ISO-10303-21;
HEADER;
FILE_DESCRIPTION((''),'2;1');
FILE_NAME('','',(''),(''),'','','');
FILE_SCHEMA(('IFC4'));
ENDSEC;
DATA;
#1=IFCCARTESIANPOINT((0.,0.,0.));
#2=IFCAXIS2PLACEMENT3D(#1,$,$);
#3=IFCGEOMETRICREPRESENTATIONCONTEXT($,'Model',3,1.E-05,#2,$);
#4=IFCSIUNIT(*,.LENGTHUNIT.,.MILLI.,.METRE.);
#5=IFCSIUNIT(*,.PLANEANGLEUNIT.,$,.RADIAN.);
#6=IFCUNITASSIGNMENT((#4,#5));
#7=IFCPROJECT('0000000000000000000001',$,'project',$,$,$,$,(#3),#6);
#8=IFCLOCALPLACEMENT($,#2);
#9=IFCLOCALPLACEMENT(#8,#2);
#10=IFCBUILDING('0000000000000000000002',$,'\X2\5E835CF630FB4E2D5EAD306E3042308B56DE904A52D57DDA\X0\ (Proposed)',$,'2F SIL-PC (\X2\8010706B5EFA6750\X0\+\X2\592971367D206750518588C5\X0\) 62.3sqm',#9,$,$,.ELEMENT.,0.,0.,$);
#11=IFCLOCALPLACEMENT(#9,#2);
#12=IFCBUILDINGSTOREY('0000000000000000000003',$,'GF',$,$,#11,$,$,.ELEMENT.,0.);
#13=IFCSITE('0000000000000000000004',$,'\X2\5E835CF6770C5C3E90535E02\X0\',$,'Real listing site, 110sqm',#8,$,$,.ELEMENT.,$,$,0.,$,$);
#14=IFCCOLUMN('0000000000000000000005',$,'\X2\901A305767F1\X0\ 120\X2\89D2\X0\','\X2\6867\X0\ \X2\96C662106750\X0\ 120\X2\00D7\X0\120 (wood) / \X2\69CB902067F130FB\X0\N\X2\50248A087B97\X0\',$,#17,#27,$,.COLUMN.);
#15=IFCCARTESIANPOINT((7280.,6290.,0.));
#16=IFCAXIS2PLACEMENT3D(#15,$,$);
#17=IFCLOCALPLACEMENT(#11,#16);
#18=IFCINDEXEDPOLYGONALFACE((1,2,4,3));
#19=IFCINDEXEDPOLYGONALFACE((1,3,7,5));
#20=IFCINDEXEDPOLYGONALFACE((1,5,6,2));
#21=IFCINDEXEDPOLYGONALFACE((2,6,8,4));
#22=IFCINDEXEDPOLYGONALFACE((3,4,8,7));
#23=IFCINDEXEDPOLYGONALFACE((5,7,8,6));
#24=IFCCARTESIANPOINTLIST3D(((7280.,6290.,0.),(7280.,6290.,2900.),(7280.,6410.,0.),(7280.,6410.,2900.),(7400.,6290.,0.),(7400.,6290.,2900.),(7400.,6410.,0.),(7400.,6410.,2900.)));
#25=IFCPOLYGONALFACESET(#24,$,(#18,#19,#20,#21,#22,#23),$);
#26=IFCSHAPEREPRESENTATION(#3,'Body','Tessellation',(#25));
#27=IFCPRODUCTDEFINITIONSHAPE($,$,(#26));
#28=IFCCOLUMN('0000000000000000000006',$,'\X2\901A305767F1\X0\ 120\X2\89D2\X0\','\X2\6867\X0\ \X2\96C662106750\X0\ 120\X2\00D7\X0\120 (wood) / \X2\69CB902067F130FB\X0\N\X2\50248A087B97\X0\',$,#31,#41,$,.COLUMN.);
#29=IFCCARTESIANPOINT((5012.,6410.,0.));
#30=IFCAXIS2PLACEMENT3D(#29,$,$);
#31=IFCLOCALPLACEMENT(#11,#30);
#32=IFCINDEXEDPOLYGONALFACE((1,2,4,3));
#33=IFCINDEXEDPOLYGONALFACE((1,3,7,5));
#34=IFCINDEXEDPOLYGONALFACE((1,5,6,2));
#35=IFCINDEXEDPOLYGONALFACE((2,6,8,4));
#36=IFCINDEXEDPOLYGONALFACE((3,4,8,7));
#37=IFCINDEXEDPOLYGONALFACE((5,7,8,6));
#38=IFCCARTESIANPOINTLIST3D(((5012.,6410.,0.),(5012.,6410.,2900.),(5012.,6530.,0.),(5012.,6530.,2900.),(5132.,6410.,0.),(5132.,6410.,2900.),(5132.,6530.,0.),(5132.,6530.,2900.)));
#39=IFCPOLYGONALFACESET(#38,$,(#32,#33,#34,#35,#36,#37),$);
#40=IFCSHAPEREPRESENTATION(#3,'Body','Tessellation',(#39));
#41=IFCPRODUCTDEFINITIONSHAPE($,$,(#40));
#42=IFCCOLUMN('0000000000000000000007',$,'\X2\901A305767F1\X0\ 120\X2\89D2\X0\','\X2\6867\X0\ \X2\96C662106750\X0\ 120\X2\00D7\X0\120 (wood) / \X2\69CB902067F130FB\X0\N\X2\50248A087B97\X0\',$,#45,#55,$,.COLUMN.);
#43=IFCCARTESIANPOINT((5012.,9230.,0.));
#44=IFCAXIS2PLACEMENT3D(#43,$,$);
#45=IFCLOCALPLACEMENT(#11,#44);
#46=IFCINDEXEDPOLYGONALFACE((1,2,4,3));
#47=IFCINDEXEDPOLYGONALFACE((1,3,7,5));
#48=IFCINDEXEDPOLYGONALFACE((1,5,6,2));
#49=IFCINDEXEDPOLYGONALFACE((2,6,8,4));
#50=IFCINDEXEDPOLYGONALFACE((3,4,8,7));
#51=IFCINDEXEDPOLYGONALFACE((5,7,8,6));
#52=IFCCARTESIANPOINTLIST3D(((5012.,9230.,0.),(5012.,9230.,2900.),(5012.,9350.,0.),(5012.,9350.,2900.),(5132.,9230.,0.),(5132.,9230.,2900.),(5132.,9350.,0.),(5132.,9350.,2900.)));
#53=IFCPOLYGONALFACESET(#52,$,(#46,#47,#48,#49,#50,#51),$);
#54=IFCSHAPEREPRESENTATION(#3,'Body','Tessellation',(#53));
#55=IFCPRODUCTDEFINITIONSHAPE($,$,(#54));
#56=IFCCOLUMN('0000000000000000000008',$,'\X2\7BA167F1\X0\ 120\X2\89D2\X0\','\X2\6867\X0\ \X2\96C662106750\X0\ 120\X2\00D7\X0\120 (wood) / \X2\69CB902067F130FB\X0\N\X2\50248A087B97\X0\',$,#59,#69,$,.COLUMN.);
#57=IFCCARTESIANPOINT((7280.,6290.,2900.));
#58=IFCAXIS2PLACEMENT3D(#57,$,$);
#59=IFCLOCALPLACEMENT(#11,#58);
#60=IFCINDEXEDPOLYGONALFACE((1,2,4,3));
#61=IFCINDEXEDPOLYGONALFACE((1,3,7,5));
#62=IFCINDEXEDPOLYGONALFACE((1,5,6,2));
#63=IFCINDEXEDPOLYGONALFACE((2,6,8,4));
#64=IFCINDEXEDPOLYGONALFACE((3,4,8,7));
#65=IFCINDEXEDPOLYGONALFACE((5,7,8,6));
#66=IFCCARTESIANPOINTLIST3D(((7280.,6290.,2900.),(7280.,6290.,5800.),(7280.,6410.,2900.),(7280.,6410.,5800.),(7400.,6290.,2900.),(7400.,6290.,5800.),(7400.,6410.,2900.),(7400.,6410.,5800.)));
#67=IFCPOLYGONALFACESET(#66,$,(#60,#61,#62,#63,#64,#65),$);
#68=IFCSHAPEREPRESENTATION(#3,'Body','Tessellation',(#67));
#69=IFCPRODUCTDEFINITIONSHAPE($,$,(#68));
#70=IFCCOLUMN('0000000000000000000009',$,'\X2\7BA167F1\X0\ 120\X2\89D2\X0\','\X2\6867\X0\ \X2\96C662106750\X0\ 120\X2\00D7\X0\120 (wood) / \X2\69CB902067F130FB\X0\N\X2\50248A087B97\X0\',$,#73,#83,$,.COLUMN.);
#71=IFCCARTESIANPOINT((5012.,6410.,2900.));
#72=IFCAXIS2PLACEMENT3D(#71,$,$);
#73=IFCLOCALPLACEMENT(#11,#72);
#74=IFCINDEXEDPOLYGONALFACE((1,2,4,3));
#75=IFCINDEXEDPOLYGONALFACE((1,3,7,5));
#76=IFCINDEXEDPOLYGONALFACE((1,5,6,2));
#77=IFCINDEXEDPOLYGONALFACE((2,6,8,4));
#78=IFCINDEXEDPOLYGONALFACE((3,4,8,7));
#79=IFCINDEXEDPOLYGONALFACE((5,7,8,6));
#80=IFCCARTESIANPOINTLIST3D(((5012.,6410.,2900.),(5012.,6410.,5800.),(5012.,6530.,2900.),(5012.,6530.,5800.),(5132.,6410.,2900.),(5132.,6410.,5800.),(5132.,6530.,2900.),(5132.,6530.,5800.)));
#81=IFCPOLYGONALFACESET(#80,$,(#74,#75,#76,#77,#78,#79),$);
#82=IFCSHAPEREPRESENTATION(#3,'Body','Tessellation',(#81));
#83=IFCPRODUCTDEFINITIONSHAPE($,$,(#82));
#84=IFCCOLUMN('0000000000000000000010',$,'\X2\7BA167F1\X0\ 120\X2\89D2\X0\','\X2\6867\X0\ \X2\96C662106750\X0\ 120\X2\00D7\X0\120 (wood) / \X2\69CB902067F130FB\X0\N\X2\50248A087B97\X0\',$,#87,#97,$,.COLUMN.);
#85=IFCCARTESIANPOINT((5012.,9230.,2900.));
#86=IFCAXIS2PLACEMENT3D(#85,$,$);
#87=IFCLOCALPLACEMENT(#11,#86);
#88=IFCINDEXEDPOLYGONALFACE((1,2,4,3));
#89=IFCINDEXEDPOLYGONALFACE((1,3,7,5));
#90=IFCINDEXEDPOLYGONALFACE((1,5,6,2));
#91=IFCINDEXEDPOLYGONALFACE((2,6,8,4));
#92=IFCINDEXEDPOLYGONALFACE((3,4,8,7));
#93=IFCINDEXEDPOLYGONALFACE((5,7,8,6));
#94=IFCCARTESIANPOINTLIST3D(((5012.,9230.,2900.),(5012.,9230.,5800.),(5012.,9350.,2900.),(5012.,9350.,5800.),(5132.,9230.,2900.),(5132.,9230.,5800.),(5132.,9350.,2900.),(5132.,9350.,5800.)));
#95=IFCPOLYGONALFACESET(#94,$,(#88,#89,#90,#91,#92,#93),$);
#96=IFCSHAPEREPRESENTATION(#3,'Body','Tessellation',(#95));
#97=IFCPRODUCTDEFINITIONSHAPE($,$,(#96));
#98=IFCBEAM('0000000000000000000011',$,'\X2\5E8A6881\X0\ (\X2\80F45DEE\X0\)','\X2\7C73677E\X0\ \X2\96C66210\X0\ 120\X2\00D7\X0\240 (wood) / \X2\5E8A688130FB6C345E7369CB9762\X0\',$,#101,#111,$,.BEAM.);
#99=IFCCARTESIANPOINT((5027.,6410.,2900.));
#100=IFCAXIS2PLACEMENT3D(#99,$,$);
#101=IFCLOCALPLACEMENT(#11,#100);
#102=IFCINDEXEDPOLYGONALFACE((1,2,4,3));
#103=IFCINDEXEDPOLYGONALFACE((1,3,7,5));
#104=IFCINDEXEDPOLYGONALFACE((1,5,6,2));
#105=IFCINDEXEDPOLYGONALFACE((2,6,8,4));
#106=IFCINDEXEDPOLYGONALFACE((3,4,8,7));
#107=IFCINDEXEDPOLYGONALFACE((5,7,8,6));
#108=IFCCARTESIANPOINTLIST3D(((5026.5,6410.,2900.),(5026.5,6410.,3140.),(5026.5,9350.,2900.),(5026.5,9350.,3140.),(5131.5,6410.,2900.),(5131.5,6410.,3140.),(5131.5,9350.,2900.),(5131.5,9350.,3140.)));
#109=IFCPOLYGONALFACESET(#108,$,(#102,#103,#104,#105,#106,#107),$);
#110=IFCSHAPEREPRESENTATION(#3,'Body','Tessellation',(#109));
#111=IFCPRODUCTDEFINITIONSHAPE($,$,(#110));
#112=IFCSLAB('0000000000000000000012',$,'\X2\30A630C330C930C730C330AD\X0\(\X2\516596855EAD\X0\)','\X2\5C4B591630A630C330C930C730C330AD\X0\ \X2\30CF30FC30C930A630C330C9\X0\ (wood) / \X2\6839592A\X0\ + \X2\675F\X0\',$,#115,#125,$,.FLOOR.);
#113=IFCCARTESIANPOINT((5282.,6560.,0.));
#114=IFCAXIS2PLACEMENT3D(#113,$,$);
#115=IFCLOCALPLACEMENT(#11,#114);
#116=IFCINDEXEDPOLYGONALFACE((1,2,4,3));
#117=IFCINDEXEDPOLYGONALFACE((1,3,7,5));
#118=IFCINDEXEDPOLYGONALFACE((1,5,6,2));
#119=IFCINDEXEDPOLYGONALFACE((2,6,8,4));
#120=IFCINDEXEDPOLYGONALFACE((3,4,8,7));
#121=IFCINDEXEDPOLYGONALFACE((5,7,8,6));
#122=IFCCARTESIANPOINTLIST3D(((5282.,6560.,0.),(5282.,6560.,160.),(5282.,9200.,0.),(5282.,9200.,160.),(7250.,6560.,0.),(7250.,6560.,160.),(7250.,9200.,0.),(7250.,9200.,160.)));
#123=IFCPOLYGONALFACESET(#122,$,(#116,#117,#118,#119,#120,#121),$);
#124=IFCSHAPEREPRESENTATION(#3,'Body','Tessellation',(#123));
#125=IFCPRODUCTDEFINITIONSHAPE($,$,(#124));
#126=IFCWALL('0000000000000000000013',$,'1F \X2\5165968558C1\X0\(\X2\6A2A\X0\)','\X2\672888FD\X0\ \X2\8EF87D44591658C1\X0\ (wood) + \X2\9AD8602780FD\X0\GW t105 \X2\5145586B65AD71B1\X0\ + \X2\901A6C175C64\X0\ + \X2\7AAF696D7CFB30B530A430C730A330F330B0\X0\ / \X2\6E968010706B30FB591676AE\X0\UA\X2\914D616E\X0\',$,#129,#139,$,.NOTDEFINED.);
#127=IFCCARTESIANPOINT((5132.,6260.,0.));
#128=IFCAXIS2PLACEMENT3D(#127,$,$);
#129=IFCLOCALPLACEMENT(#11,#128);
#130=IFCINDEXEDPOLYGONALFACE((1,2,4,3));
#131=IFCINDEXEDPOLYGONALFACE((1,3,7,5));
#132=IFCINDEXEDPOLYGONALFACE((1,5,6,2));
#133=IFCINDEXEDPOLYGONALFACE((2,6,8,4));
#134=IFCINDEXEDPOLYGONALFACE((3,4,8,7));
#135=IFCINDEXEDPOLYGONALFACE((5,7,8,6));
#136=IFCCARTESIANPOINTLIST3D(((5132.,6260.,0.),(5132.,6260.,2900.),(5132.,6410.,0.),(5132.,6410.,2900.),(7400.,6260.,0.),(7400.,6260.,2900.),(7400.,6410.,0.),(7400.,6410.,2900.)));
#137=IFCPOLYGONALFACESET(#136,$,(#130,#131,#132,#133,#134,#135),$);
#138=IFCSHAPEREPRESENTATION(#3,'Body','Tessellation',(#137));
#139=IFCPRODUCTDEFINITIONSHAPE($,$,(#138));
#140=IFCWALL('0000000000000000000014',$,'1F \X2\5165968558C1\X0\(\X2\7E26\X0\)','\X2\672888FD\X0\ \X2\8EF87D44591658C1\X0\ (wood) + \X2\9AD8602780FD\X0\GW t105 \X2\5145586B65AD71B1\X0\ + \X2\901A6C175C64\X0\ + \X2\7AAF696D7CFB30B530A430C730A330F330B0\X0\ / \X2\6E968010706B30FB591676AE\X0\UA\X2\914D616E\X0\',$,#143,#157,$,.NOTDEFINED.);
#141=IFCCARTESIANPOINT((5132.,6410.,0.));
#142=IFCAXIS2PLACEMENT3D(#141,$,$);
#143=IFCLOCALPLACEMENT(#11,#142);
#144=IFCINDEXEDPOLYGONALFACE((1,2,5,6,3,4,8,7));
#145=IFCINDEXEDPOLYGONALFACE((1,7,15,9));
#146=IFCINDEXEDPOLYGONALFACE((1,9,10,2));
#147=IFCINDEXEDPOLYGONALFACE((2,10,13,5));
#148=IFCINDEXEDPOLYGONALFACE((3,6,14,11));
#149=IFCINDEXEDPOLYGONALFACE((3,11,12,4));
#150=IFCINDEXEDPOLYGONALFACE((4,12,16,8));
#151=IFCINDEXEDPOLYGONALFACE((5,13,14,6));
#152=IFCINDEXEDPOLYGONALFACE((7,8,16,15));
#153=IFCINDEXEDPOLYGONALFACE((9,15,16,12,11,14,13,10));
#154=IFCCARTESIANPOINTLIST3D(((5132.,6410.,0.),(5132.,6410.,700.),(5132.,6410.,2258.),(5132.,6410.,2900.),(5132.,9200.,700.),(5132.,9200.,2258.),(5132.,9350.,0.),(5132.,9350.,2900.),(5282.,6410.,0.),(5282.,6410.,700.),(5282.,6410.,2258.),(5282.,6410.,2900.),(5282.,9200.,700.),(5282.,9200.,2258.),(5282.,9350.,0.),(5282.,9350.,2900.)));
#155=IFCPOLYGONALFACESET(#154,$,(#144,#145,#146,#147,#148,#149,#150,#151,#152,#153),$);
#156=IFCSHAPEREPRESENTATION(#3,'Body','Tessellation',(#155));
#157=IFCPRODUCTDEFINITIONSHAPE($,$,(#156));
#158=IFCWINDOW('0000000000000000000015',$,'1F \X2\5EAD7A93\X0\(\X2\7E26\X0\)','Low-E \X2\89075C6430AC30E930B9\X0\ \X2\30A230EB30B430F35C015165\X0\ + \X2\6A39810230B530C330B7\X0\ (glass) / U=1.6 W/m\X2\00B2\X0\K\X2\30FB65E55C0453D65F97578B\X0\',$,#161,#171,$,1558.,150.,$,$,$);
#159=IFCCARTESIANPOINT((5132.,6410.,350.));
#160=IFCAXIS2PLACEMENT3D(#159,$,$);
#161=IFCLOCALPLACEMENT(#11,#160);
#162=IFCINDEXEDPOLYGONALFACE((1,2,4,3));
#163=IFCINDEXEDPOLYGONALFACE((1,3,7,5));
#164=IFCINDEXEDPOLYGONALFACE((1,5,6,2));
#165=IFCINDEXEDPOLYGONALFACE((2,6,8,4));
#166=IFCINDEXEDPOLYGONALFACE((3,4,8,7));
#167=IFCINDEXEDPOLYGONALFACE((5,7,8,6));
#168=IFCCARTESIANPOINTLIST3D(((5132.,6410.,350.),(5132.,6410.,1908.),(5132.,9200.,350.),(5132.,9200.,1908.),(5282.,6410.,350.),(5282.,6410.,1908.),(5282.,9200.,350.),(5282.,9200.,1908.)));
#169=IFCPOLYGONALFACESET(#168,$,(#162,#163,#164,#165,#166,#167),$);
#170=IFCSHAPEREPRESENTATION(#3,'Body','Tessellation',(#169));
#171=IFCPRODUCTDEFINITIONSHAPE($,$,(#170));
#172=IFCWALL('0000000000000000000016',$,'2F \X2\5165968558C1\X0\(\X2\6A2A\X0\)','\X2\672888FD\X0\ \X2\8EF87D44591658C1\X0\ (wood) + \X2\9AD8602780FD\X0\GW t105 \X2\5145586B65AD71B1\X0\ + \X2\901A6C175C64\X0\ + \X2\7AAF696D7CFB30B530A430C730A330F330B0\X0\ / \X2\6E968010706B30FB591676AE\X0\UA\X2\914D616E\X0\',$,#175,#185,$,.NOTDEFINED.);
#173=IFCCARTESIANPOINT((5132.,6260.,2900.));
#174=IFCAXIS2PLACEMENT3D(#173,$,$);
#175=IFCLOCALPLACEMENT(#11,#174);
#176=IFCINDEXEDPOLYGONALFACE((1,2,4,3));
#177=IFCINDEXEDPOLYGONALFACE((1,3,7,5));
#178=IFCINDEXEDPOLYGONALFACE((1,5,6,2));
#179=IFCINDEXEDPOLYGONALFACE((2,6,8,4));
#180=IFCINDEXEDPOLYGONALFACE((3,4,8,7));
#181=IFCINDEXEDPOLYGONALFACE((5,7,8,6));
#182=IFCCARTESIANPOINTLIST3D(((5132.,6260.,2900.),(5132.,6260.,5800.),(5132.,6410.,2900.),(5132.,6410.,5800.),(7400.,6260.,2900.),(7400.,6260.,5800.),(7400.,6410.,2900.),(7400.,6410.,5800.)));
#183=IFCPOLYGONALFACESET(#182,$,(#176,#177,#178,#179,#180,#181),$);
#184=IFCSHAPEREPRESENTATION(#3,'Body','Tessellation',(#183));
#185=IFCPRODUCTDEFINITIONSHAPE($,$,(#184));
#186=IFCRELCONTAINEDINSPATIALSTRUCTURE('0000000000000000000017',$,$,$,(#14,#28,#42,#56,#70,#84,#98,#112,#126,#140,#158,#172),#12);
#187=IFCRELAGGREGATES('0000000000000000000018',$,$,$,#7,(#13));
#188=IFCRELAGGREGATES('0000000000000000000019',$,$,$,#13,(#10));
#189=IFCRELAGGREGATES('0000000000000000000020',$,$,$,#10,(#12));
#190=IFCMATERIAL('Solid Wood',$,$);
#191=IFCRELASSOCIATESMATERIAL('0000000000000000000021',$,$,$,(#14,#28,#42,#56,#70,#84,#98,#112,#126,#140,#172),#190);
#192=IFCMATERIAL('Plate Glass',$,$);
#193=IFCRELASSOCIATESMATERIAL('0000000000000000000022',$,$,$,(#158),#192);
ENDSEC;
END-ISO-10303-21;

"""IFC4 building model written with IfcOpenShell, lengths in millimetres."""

from ifc_helpers import new_model, si_unit, frame, frame_2d, origin, place, context, project, spatial, rectangle, extrude, material, element, fill, save


model = new_model("IFC4")

# Units and contexts
model_context = context("Model", 3, precision=1e-05, world=origin())
ifc_project = project(units=[si_unit("LENGTHUNIT", "METRE", prefix="MILLI"), si_unit("PLANEANGLEUNIT", "RADIAN")], contexts=[model_context])

# Site, building, storey
site_placement = place(None, origin())
site = spatial("IfcSite", under=ifc_project, at=site_placement, Name="広島県尾道市", ObjectType="Real listing site, 110sqm", CompositionType="ELEMENT", RefElevation=0.0)
building_placement = place(site_placement, origin())
building = spatial("IfcBuilding", under=site, at=building_placement, Name="広島・中庭のある回遊動線 (Proposed)", ObjectType="2F SIL-PC (耐火建材+天然素材内装) 62.3sqm", CompositionType="ELEMENT", ElevationOfRefHeight=0.0, ElevationOfTerrain=0.0)
storey_placement = place(building_placement, origin())
storey = spatial("IfcBuildingStorey", under=building, at=storey_placement, Name="GF", CompositionType="ELEMENT", Elevation=0.0)

# Columns
ifc_material_1 = material(Name="Solid Wood")
column_1_placement = place(storey_placement, frame((7280.0, 6290.0, 0.0)))
element("IfcColumn", 1, at=column_1_placement, inside=storey, material=ifc_material_1, Name="通し柱 120角", Description="桧 集成材 120×120 (wood) / 構造柱・N値計算", PredefinedType="COLUMN", context=model_context, shape_type="SweptSolid", body=[
    extrude(rectangle(XDim=120.0, YDim=120.0, at=frame_2d((60.0, 60.0))), frame((7280.0, 6290.0, 0.0)), (0.0, 0.0, 1.0), 2900.0),
])
column_2_placement = place(storey_placement, frame((5012.0, 6410.0, 0.0)))
element("IfcColumn", 2, at=column_2_placement, inside=storey, material=ifc_material_1, Name="通し柱 120角", Description="桧 集成材 120×120 (wood) / 構造柱・N値計算", PredefinedType="COLUMN", context=model_context, shape_type="SweptSolid", body=[
    extrude(rectangle(XDim=120.0, YDim=120.0, at=frame_2d((60.0, 60.0))), frame((5012.0, 6410.0, 0.0)), (0.0, 0.0, 1.0), 2900.0),
])
column_3_placement = place(storey_placement, frame((5012.0, 9230.0, 0.0)))
element("IfcColumn", 3, at=column_3_placement, inside=storey, material=ifc_material_1, Name="通し柱 120角", Description="桧 集成材 120×120 (wood) / 構造柱・N値計算", PredefinedType="COLUMN", context=model_context, shape_type="SweptSolid", body=[
    extrude(rectangle(XDim=120.0, YDim=120.0, at=frame_2d((60.0, 60.0))), frame((5012.0, 9230.0, 0.0)), (0.0, 0.0, 1.0), 2900.0),
])
column_4_placement = place(storey_placement, frame((7280.0, 6290.0, 2900.0)))
element("IfcColumn", 4, at=column_4_placement, inside=storey, material=ifc_material_1, Name="管柱 120角", Description="桧 集成材 120×120 (wood) / 構造柱・N値計算", PredefinedType="COLUMN", context=model_context, shape_type="SweptSolid", body=[
    extrude(rectangle(XDim=120.0, YDim=120.0, at=frame_2d((60.0, 60.0))), frame((7280.0, 6290.0, 2900.0)), (0.0, 0.0, 1.0), 2900.0),
])
column_5_placement = place(storey_placement, frame((5012.0, 6410.0, 2900.0)))
element("IfcColumn", 5, at=column_5_placement, inside=storey, material=ifc_material_1, Name="管柱 120角", Description="桧 集成材 120×120 (wood) / 構造柱・N値計算", PredefinedType="COLUMN", context=model_context, shape_type="SweptSolid", body=[
    extrude(rectangle(XDim=120.0, YDim=120.0, at=frame_2d((60.0, 60.0))), frame((5012.0, 6410.0, 2900.0)), (0.0, 0.0, 1.0), 2900.0),
])
column_6_placement = place(storey_placement, frame((5012.0, 9230.0, 2900.0)))
element("IfcColumn", 6, at=column_6_placement, inside=storey, material=ifc_material_1, Name="管柱 120角", Description="桧 集成材 120×120 (wood) / 構造柱・N値計算", PredefinedType="COLUMN", context=model_context, shape_type="SweptSolid", body=[
    extrude(rectangle(XDim=120.0, YDim=120.0, at=frame_2d((60.0, 60.0))), frame((5012.0, 9230.0, 2900.0)), (0.0, 0.0, 1.0), 2900.0),
])

# Beam
beam_1_placement = place(storey_placement, frame((5027.0, 6410.0, 2900.0)))
element("IfcBeam", 7, at=beam_1_placement, inside=storey, material=ifc_material_1, Name="床梁 (胴差)", Description="米松 集成 120×240 (wood) / 床梁・水平構面", PredefinedType="BEAM", context=model_context, shape_type="SweptSolid", body=[
    extrude(rectangle(XDim=105.0, YDim=2940.0, at=frame_2d((52.0, 1470.0))), frame((5027.0, 6410.0, 2900.0)), (0.0, 0.0, 1.0), 240.0),
])

# Slab
slab_placement = place(storey_placement, frame((5282.0, 6560.0, 0.0)))
element("IfcSlab", 8, at=slab_placement, inside=storey, material=ifc_material_1, Name="ウッドデッキ(入隅庭)", Description="屋外ウッドデッキ ハードウッド (wood) / 根太 + 束", PredefinedType="FLOOR", context=model_context, shape_type="SweptSolid", body=[
    extrude(rectangle(XDim=1968.0, YDim=2640.0, at=frame_2d((984.0, 1320.0))), frame((5282.0, 6560.0, 0.0)), (0.0, 0.0, 1.0), 160.0),
])

# Wall
wall_1_placement = place(storey_placement, frame((5132.0, 6260.0, 0.0)))
element("IfcWall", 9, at=wall_1_placement, inside=storey, material=ifc_material_1, Name="1F 入隅壁(横)", Description="木製 軸組外壁 (wood) + 高性能GW t105 充填断熱 + 通気層 + 窯業系サイディング / 準耐火・外皮UA配慮", PredefinedType="NOTDEFINED", context=model_context, shape_type="SweptSolid", body=[
    extrude(rectangle(XDim=2268.0, YDim=150.0, at=frame_2d((1134.0, 75.0))), frame((5132.0, 6260.0, 0.0)), (0.0, 0.0, 1.0), 2900.0),
])

# Wall, opening, window
wall_2_placement = place(storey_placement, frame((5132.0, 6410.0, 0.0)))
wall_2 = element("IfcWall", 10, at=wall_2_placement, inside=storey, material=ifc_material_1, Name="1F 入隅壁(縦)", Description="木製 軸組外壁 (wood) + 高性能GW t105 充填断熱 + 通気層 + 窯業系サイディング / 準耐火・外皮UA配慮", PredefinedType="NOTDEFINED", context=model_context, shape_type="SweptSolid", body=[
    extrude(rectangle(XDim=150.0, YDim=2940.0, at=frame_2d((75.0, 1470.0))), frame((5132.0, 6410.0, 0.0)), (0.0, 0.0, 1.0), 2900.0),
])
opening_1_placement = place(storey_placement, frame((5132.0, 6410.0, 350.0)))
opening_1 = element("IfcOpeningElement", 11, at=opening_1_placement, cuts=wall_2, PredefinedType="NOTDEFINED", context=model_context, shape_type="SweptSolid", body=[
    extrude(rectangle(XDim=150.0, YDim=2790.0, at=frame_2d((75.0, 1395.0))), frame((5132.0, 6410.0, 350.0)), (0.0, 0.0, 1.0), 1558.0),
])
ifc_material_2 = material(Name="Plate Glass")
window_1_placement = place(storey_placement, frame((5132.0, 6410.0, 350.0)))
window_1 = element("IfcWindow", 12, at=window_1_placement, inside=storey, material=ifc_material_2, Name="1F 庭窓(縦)", Description="Low-E 複層ガラス アルゴン封入 + 樹脂サッシ (glass) / U=1.6 W/m²K・日射取得型", OverallHeight=1558.0, OverallWidth=150.0, context=model_context, shape_type="SweptSolid", body=[
    extrude(rectangle(XDim=150.0, YDim=2790.0, at=frame_2d((75.0, 1395.0))), frame((5132.0, 6410.0, 350.0)), (0.0, 0.0, 1.0), 1558.0),
])
fill(opening_1, window_1)

# Wall
wall_3_placement = place(storey_placement, frame((5132.0, 6260.0, 2900.0)))
element("IfcWall", 13, at=wall_3_placement, inside=storey, material=ifc_material_1, Name="2F 入隅壁(横)", Description="木製 軸組外壁 (wood) + 高性能GW t105 充填断熱 + 通気層 + 窯業系サイディング / 準耐火・外皮UA配慮", PredefinedType="NOTDEFINED", context=model_context, shape_type="SweptSolid", body=[
    extrude(rectangle(XDim=2268.0, YDim=150.0, at=frame_2d((1134.0, 75.0))), frame((5132.0, 6260.0, 2900.0)), (0.0, 0.0, 1.0), 2900.0),
])

save(model, "model.ifc")
